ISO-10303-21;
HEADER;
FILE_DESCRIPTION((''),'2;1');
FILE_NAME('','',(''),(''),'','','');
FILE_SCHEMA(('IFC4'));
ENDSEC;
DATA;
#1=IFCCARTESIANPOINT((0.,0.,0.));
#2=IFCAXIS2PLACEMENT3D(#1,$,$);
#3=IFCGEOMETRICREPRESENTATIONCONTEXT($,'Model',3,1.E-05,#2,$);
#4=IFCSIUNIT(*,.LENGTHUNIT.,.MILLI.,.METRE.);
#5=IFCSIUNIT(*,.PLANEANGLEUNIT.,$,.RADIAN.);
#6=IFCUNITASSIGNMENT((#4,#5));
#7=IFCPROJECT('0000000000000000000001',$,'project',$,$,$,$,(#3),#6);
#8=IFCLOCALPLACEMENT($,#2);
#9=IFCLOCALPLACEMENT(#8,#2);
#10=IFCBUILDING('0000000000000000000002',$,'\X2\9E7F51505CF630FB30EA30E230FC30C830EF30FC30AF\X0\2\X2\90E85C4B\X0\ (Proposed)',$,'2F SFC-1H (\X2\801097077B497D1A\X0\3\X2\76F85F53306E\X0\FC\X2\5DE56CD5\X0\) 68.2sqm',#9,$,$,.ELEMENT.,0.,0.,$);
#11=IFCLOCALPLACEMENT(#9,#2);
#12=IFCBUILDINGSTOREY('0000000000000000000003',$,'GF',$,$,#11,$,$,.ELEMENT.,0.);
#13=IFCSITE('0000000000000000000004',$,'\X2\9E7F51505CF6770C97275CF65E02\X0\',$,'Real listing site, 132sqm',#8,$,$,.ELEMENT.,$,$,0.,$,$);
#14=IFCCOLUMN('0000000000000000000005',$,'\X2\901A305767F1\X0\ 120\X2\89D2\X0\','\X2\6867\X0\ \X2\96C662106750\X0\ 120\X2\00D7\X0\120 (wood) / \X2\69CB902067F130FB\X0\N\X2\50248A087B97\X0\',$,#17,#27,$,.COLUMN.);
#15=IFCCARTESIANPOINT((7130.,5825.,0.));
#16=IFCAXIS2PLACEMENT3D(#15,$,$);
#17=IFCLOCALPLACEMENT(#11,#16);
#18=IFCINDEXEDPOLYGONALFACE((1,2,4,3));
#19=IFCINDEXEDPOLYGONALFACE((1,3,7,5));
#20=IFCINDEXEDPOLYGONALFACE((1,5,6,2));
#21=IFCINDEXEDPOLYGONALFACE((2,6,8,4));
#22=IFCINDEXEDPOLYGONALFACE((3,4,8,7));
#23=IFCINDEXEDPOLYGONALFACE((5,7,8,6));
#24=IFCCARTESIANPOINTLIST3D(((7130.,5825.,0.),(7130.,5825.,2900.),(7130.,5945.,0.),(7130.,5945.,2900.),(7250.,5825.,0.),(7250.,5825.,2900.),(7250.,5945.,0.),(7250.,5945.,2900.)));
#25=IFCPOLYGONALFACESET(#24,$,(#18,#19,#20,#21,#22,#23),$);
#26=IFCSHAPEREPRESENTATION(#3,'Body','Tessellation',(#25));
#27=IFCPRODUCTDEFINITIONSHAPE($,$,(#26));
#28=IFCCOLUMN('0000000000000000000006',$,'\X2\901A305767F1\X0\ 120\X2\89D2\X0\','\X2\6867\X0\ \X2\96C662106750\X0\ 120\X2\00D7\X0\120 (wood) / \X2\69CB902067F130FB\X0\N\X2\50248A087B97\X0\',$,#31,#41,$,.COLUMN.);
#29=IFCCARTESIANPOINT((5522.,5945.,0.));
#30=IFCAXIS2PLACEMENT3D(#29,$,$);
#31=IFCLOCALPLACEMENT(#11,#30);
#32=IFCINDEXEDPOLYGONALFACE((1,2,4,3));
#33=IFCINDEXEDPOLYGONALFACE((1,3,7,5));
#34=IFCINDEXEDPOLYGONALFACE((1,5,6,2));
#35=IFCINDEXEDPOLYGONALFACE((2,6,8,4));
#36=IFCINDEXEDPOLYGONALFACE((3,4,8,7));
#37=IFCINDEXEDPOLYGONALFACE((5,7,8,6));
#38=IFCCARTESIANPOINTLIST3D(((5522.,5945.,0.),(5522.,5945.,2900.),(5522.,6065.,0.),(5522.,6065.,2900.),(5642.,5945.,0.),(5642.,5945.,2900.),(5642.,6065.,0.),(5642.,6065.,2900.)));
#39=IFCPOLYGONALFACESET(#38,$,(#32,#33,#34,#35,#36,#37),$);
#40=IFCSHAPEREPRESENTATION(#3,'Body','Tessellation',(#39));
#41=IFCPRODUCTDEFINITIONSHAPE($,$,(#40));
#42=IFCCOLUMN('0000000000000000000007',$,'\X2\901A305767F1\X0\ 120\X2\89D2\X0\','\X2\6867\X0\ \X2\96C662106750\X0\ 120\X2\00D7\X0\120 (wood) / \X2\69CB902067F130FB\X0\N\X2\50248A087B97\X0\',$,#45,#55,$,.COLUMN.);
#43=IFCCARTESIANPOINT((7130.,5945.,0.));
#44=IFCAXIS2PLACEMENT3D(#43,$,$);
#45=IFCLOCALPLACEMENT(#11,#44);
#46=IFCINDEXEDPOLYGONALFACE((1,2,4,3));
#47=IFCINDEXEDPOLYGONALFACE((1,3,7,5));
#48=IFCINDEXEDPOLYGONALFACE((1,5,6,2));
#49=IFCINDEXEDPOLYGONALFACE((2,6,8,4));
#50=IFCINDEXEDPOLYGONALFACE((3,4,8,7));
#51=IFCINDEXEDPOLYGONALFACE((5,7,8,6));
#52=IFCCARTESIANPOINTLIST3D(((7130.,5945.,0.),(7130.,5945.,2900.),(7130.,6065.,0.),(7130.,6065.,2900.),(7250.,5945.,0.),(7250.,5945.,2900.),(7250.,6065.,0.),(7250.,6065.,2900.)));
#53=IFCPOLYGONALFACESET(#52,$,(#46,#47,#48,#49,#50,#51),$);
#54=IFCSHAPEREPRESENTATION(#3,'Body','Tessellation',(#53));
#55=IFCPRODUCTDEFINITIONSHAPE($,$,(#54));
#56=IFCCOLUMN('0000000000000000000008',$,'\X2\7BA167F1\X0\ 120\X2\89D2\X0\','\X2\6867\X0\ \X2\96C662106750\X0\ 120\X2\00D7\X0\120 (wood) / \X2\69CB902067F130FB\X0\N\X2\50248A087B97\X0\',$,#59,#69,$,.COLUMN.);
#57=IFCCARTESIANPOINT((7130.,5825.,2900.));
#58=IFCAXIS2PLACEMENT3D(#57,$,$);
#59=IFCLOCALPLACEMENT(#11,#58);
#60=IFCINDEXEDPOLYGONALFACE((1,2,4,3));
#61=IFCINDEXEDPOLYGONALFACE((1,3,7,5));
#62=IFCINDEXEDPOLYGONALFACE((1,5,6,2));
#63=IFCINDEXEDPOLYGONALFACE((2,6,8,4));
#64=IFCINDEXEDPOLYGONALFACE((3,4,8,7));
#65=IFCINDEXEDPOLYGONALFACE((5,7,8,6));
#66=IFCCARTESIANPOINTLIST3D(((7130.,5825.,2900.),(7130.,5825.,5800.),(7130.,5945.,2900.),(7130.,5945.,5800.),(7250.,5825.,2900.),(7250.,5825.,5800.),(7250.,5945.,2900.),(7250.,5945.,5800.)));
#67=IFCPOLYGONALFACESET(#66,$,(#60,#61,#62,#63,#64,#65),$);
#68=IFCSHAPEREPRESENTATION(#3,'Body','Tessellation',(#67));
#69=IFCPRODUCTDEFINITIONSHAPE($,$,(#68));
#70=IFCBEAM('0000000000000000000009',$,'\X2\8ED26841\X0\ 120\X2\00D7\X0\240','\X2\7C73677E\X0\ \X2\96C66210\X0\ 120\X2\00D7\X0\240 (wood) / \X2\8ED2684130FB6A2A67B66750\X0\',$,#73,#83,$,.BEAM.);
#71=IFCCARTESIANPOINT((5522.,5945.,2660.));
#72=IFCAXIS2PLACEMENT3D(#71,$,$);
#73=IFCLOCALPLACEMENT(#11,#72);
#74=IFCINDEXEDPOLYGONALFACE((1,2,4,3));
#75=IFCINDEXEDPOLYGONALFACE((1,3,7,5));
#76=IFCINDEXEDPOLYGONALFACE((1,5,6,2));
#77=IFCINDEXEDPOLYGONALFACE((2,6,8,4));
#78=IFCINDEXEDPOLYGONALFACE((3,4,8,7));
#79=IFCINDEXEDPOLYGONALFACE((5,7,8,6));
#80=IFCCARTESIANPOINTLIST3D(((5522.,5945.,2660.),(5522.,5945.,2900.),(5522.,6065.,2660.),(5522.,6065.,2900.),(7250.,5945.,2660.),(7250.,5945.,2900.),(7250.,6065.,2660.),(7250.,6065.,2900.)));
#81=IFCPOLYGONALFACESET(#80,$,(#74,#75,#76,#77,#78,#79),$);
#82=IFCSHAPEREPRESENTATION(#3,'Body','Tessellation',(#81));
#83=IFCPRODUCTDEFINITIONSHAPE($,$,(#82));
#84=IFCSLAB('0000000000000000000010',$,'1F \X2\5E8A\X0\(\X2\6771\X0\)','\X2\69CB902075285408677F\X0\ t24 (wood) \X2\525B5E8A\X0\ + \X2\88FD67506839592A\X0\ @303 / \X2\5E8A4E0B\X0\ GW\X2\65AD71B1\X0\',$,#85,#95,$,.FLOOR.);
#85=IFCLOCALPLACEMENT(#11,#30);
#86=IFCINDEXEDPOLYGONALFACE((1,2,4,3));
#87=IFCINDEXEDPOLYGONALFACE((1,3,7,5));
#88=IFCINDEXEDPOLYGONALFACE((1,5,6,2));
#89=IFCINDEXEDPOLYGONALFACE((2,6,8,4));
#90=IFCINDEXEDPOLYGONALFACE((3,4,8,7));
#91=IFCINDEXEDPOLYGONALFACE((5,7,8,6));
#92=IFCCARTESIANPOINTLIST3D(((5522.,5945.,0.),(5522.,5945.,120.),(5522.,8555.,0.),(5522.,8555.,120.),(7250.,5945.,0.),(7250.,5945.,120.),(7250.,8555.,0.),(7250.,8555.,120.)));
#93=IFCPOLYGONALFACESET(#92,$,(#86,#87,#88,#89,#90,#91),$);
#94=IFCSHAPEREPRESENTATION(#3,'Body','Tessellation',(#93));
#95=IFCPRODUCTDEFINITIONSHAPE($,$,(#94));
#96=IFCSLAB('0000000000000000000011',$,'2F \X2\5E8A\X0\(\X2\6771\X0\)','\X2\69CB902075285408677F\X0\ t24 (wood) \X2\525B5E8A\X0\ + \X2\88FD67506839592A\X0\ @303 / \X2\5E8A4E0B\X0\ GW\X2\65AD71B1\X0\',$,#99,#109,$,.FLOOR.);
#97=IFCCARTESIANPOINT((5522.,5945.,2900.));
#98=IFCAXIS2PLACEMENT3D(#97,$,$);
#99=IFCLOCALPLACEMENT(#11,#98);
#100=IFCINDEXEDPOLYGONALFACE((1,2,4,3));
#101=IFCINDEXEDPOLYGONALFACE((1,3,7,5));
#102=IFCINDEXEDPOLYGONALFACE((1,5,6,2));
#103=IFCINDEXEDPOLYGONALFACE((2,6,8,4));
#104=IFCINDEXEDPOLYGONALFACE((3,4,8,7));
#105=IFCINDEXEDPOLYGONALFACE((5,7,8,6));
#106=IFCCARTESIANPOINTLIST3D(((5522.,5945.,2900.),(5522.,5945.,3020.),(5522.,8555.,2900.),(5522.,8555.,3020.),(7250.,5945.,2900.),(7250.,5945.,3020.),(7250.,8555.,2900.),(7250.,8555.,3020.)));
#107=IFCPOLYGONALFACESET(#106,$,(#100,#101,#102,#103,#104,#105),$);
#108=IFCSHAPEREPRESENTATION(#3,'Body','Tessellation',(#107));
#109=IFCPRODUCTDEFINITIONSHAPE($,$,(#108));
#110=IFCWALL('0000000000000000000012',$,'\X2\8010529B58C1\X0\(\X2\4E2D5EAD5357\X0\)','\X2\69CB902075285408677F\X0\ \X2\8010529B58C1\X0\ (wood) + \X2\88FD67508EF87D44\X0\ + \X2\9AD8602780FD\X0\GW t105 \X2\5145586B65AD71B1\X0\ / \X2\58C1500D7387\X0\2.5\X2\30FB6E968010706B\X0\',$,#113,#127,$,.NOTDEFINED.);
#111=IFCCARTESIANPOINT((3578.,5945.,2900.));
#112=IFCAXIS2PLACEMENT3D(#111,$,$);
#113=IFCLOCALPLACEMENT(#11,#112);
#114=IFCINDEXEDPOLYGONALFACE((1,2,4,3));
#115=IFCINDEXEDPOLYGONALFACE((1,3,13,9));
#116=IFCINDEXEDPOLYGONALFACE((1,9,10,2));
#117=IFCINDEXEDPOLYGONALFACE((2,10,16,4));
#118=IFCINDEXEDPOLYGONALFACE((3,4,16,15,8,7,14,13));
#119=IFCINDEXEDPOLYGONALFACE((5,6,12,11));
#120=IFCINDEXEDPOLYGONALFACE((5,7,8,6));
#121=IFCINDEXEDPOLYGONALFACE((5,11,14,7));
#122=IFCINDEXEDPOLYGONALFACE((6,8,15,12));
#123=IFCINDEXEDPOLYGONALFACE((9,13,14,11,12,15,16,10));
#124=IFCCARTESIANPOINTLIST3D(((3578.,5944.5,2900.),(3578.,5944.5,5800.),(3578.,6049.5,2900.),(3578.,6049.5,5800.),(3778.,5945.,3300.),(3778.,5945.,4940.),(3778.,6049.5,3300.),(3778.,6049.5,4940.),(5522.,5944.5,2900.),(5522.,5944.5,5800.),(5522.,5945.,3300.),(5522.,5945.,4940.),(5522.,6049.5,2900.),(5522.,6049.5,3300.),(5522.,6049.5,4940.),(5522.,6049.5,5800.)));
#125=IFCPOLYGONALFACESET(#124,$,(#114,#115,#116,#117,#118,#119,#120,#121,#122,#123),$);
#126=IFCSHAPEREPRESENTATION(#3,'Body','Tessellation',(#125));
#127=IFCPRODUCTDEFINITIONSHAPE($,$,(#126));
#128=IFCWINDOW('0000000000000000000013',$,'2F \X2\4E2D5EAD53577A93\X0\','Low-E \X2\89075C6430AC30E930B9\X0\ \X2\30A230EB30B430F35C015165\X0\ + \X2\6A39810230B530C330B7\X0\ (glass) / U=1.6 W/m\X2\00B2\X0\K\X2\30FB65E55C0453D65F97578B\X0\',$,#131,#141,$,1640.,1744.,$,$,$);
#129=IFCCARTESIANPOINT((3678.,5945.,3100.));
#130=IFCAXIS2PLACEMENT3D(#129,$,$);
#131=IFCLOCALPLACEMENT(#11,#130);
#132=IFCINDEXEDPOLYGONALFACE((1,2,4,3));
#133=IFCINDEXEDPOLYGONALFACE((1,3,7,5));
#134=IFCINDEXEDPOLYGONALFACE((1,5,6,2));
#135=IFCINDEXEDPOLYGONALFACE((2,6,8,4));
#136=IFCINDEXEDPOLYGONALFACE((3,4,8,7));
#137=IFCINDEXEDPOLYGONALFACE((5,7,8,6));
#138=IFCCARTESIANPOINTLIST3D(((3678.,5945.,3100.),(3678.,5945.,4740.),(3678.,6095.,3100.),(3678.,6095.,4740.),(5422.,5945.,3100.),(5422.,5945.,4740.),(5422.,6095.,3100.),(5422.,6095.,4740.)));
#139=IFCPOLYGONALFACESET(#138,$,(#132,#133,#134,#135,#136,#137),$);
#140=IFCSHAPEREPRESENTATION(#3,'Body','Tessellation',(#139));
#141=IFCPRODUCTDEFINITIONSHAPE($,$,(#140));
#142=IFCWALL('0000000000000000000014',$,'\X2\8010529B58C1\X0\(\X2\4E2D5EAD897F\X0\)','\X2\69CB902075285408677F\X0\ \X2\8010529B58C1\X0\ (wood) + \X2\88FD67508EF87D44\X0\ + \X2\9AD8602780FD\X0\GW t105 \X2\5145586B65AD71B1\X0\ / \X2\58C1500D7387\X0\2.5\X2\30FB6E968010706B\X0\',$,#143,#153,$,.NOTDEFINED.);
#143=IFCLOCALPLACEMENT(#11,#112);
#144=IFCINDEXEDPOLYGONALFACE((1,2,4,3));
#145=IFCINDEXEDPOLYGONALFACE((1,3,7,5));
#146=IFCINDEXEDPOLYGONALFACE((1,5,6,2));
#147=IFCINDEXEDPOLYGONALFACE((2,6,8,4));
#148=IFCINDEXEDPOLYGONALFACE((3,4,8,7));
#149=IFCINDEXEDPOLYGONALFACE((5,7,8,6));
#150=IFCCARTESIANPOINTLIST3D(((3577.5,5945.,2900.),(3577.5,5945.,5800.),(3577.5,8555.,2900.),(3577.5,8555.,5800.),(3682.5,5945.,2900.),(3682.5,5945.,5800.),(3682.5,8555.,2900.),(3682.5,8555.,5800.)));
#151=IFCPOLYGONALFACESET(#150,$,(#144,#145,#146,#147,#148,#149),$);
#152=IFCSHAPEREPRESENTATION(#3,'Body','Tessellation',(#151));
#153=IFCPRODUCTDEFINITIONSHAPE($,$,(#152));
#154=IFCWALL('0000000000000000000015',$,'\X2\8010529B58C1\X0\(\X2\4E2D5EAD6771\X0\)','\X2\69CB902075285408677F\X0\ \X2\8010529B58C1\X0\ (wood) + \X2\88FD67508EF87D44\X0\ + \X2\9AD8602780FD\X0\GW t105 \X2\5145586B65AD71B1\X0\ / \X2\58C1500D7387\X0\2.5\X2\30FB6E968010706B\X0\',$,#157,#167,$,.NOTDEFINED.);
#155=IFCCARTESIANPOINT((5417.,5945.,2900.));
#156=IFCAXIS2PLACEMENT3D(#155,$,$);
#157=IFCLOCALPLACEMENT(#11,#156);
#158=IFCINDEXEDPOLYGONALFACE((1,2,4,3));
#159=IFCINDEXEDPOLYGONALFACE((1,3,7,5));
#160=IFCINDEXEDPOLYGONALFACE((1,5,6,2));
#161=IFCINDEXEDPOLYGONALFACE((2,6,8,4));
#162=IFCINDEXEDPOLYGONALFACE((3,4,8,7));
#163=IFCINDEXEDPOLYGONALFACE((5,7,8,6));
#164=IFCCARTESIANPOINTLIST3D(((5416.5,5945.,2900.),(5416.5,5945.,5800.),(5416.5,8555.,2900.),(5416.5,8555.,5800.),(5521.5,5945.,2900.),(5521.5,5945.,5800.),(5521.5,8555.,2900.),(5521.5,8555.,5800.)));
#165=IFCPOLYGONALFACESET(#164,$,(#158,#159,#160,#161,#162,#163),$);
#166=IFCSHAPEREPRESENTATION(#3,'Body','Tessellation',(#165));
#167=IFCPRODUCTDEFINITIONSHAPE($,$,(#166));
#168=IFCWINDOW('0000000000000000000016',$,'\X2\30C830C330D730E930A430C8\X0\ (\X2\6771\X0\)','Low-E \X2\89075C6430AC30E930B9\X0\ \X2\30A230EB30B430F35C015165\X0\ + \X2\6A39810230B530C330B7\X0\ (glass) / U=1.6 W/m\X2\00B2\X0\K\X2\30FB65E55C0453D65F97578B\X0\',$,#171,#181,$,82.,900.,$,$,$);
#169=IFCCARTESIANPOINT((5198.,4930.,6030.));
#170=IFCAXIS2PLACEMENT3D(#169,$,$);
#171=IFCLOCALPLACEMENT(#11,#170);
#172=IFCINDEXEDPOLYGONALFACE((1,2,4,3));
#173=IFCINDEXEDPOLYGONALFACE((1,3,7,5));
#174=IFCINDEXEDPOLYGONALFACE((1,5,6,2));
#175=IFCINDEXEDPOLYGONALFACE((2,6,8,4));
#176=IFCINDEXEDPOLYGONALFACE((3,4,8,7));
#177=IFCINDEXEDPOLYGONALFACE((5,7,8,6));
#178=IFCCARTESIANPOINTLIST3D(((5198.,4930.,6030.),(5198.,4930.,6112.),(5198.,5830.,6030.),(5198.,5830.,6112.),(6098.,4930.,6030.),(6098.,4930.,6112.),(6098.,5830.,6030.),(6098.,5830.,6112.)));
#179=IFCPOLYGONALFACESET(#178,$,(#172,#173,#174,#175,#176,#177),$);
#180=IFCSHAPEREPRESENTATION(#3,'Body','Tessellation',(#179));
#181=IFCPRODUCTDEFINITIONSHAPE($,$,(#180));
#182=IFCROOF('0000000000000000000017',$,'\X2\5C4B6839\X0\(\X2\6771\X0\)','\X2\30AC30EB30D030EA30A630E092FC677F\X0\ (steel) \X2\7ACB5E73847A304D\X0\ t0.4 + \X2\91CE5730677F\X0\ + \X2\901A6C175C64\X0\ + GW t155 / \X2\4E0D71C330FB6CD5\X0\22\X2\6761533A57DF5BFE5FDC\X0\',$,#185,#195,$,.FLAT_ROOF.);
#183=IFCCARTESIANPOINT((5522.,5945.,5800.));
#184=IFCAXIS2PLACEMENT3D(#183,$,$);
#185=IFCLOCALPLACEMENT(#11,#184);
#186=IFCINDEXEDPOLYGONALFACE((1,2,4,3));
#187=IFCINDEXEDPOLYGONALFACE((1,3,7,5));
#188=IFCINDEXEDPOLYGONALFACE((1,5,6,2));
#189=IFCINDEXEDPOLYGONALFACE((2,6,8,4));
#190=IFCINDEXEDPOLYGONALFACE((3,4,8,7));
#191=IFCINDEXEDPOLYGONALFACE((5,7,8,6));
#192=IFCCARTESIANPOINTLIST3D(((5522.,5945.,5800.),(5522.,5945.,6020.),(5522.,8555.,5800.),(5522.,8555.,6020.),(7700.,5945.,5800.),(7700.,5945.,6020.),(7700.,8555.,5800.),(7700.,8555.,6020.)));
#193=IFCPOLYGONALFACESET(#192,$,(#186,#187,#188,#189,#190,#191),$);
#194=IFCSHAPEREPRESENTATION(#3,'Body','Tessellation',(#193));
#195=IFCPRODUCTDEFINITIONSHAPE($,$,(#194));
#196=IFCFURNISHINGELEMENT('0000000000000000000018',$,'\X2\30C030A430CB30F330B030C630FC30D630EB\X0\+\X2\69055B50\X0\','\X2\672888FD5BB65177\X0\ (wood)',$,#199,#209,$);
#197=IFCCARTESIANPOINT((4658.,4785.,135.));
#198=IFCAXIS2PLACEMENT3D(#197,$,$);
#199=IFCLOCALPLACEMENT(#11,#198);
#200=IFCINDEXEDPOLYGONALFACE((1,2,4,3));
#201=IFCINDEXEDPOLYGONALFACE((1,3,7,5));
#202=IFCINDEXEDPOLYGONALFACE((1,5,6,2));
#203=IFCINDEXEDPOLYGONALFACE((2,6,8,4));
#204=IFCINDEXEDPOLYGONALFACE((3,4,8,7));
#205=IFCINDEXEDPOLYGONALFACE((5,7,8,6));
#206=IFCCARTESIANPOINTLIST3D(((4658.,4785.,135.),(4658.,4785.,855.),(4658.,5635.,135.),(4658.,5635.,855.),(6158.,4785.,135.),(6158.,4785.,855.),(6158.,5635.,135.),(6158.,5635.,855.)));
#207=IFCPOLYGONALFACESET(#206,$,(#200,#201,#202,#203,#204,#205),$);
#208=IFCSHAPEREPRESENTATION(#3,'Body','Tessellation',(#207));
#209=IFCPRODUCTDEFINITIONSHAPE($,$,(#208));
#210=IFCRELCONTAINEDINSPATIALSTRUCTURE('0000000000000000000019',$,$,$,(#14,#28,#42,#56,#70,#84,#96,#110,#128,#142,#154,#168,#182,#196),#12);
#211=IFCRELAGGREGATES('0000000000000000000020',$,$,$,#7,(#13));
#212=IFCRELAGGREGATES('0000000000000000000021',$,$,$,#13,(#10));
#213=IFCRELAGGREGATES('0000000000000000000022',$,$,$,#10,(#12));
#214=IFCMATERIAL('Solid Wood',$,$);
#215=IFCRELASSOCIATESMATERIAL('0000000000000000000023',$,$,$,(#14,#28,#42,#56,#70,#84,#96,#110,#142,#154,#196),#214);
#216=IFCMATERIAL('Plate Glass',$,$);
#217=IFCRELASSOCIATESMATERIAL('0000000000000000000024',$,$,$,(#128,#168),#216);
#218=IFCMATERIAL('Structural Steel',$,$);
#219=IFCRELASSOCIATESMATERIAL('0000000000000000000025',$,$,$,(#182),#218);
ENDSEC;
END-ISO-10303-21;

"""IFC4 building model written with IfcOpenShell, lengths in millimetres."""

from ifc_helpers import new_model, si_unit, frame, frame_2d, origin, place, context, project, spatial, rectangle, extrude, material, element, fill, save


model = new_model("IFC4")

# Units and contexts
model_context = context("Model", 3, precision=1e-05, world=origin())
ifc_project = project(units=[si_unit("LENGTHUNIT", "METRE", prefix="MILLI"), si_unit("PLANEANGLEUNIT", "RADIAN")], contexts=[model_context])

# Site, building, storey
site_placement = place(None, origin())
site = spatial("IfcSite", under=ifc_project, at=site_placement, Name="鹿児島県霧島市", ObjectType="Real listing site, 132sqm", CompositionType="ELEMENT", RefElevation=0.0)
building_placement = place(site_placement, origin())
building = spatial("IfcBuilding", under=site, at=building_placement, Name="鹿児島・リモートワーク2部屋 (Proposed)", ObjectType="2F SFC-1H (耐震等級3相当のFC工法) 68.2sqm", CompositionType="ELEMENT", ElevationOfRefHeight=0.0, ElevationOfTerrain=0.0)
storey_placement = place(building_placement, origin())
storey = spatial("IfcBuildingStorey", under=building, at=storey_placement, Name="GF", CompositionType="ELEMENT", Elevation=0.0)

# Columns
ifc_material_1 = material(Name="Solid Wood")
column_1_placement = place(storey_placement, frame((7130.0, 5825.0, 0.0)))
element("IfcColumn", 1, at=column_1_placement, inside=storey, material=ifc_material_1, Name="通し柱 120角", Description="桧 集成材 120×120 (wood) / 構造柱・N値計算", PredefinedType="COLUMN", context=model_context, shape_type="SweptSolid", body=[
    extrude(rectangle(XDim=120.0, YDim=120.0, at=frame_2d((60.0, 60.0))), frame((7130.0, 5825.0, 0.0)), (0.0, 0.0, 1.0), 2900.0),
])
column_2_placement = place(storey_placement, frame((5522.0, 5945.0, 0.0)))
element("IfcColumn", 2, at=column_2_placement, inside=storey, material=ifc_material_1, Name="通し柱 120角", Description="桧 集成材 120×120 (wood) / 構造柱・N値計算", PredefinedType="COLUMN", context=model_context, shape_type="SweptSolid", body=[
    extrude(rectangle(XDim=120.0, YDim=120.0, at=frame_2d((60.0, 60.0))), frame((5522.0, 5945.0, 0.0)), (0.0, 0.0, 1.0), 2900.0),
])
column_3_placement = place(storey_placement, frame((7130.0, 5945.0, 0.0)))
element("IfcColumn", 3, at=column_3_placement, inside=storey, material=ifc_material_1, Name="通し柱 120角", Description="桧 集成材 120×120 (wood) / 構造柱・N値計算", PredefinedType="COLUMN", context=model_context, shape_type="SweptSolid", body=[
    extrude(rectangle(XDim=120.0, YDim=120.0, at=frame_2d((60.0, 60.0))), frame((7130.0, 5945.0, 0.0)), (0.0, 0.0, 1.0), 2900.0),
])
column_4_placement = place(storey_placement, frame((7130.0, 5825.0, 2900.0)))
element("IfcColumn", 4, at=column_4_placement, inside=storey, material=ifc_material_1, Name="管柱 120角", Description="桧 集成材 120×120 (wood) / 構造柱・N値計算", PredefinedType="COLUMN", context=model_context, shape_type="SweptSolid", body=[
    extrude(rectangle(XDim=120.0, YDim=120.0, at=frame_2d((60.0, 60.0))), frame((7130.0, 5825.0, 2900.0)), (0.0, 0.0, 1.0), 2900.0),
])

# Beam
beam_1_placement = place(storey_placement, frame((5522.0, 5945.0, 2660.0)))
element("IfcBeam", 5, at=beam_1_placement, inside=storey, material=ifc_material_1, Name="軒桁 120×240", Description="米松 集成 120×240 (wood) / 軒桁・横架材", PredefinedType="BEAM", context=model_context, shape_type="SweptSolid", body=[
    extrude(rectangle(XDim=1728.0, YDim=120.0, at=frame_2d((864.0, 60.0))), frame((5522.0, 5945.0, 2660.0)), (0.0, 0.0, 1.0), 240.0),
])

# Slabs
slab_1_placement = place(storey_placement, frame((5522.0, 5945.0, 0.0)))
element("IfcSlab", 6, at=slab_1_placement, inside=storey, material=ifc_material_1, Name="1F 床(東)", Description="構造用合板 t24 (wood) 剛床 + 製材根太 @303 / 床下 GW断熱", PredefinedType="FLOOR", context=model_context, shape_type="SweptSolid", body=[
    extrude(rectangle(XDim=1728.0, YDim=2610.0, at=frame_2d((864.0, 1305.0))), frame((5522.0, 5945.0, 0.0)), (0.0, 0.0, 1.0), 120.0),
])
slab_2_placement = place(storey_placement, frame((5522.0, 5945.0, 2900.0)))
element("IfcSlab", 7, at=slab_2_placement, inside=storey, material=ifc_material_1, Name="2F 床(東)", Description="構造用合板 t24 (wood) 剛床 + 製材根太 @303 / 床下 GW断熱", PredefinedType="FLOOR", context=model_context, shape_type="SweptSolid", body=[
    extrude(rectangle(XDim=1728.0, YDim=2610.0, at=frame_2d((864.0, 1305.0))), frame((5522.0, 5945.0, 2900.0)), (0.0, 0.0, 1.0), 120.0),
])

# Wall, opening, window
wall_1_placement = place(storey_placement, frame((3578.0, 5945.0, 2900.0)))
wall_1 = element("IfcWall", 8, at=wall_1_placement, inside=storey, material=ifc_material_1, Name="耐力壁(中庭南)", Description="構造用合板 耐力壁 (wood) + 製材軸組 + 高性能GW t105 充填断熱 / 壁倍率2.5・準耐火", PredefinedType="NOTDEFINED", context=model_context, shape_type="SweptSolid", body=[
    extrude(rectangle(XDim=1944.0, YDim=105.0, at=frame_2d((972.0, 52.0))), frame((3578.0, 5945.0, 2900.0)), (0.0, 0.0, 1.0), 2900.0),
])
opening_placement = place(storey_placement, frame((3678.0, 5945.0, 3100.0)))
opening = element("IfcOpeningElement", 9, at=opening_placement, cuts=wall_1, PredefinedType="NOTDEFINED", context=model_context, shape_type="SweptSolid", body=[
    extrude(rectangle(XDim=1744.0, YDim=150.0, at=frame_2d((872.0, 75.0))), frame((3678.0, 5945.0, 3100.0)), (0.0, 0.0, 1.0), 1640.0),
])
ifc_material_2 = material(Name="Plate Glass")
window_1_placement = place(storey_placement, frame((3678.0, 5945.0, 3100.0)))
window_1 = element("IfcWindow", 10, at=window_1_placement, inside=storey, material=ifc_material_2, Name="2F 中庭南窓", Description="Low-E 複層ガラス アルゴン封入 + 樹脂サッシ (glass) / U=1.6 W/m²K・日射取得型", OverallHeight=1640.0, OverallWidth=1744.0, context=model_context, shape_type="SweptSolid", body=[
    extrude(rectangle(XDim=1744.0, YDim=150.0, at=frame_2d((872.0, 75.0))), frame((3678.0, 5945.0, 3100.0)), (0.0, 0.0, 1.0), 1640.0),
])
fill(opening, window_1)

# Walls
wall_2_placement = place(storey_placement, frame((3578.0, 5945.0, 2900.0)))
element("IfcWall", 11, at=wall_2_placement, inside=storey, material=ifc_material_1, Name="耐力壁(中庭西)", Description="構造用合板 耐力壁 (wood) + 製材軸組 + 高性能GW t105 充填断熱 / 壁倍率2.5・準耐火", PredefinedType="NOTDEFINED", context=model_context, shape_type="SweptSolid", body=[
    extrude(rectangle(XDim=105.0, YDim=2610.0, at=frame_2d((52.0, 1305.0))), frame((3578.0, 5945.0, 2900.0)), (0.0, 0.0, 1.0), 2900.0),
])
wall_3_placement = place(storey_placement, frame((5417.0, 5945.0, 2900.0)))
element("IfcWall", 12, at=wall_3_placement, inside=storey, material=ifc_material_1, Name="耐力壁(中庭東)", Description="構造用合板 耐力壁 (wood) + 製材軸組 + 高性能GW t105 充填断熱 / 壁倍率2.5・準耐火", PredefinedType="NOTDEFINED", context=model_context, shape_type="SweptSolid", body=[
    extrude(rectangle(XDim=105.0, YDim=2610.0, at=frame_2d((52.0, 1305.0))), frame((5417.0, 5945.0, 2900.0)), (0.0, 0.0, 1.0), 2900.0),
])

# Window
window_2_placement = place(storey_placement, frame((5198.0, 4930.0, 6030.0)))
element("IfcWindow", 13, at=window_2_placement, inside=storey, material=ifc_material_2, Name="トップライト (東)", Description="Low-E 複層ガラス アルゴン封入 + 樹脂サッシ (glass) / U=1.6 W/m²K・日射取得型", OverallHeight=82.0, OverallWidth=900.0, context=model_context, shape_type="SweptSolid", body=[
    extrude(rectangle(XDim=900.0, YDim=900.0, at=frame_2d((450.0, 450.0))), frame((5198.0, 4930.0, 6030.0)), (0.0, 0.0, 1.0), 82.0),
])

# Roof
ifc_material_3 = material(Name="Structural Steel")
for number, where, name in (
    (14, (5522.0, 5945.0, 5800.0), "屋根(東)"),
):
    element("IfcRoof", number, at=place(storey_placement, frame(where)), inside=storey, material=ifc_material_3, Name=name, Description="ガルバリウム鋼板 (steel) 立平葺き t0.4 + 野地板 + 通気層 + GW t155 / 不燃・法22条区域対応", PredefinedType="FLAT_ROOF", context=model_context, shape_type="SweptSolid", body=[
        extrude(rectangle(XDim=2178.0, YDim=2610.0, at=frame_2d((1089.0, 1305.0))), frame((5522.0, 5945.0, 5800.0)), (0.0, 0.0, 1.0), 220.0),
    ])

# Furnishing element
furnishing_1_placement = place(storey_placement, frame((4658.0, 4785.0, 135.0)))
element("IfcFurnishingElement", 15, at=furnishing_1_placement, inside=storey, material=ifc_material_1, Name="ダイニングテーブル+椅子", Description="木製家具 (wood)", context=model_context, shape_type="SweptSolid", body=[
    extrude(rectangle(XDim=1500.0, YDim=850.0, at=frame_2d((750.0, 425.0))), frame((4658.0, 4785.0, 135.0)), (0.0, 0.0, 1.0), 720.0),
])

save(model, "model.ifc")
